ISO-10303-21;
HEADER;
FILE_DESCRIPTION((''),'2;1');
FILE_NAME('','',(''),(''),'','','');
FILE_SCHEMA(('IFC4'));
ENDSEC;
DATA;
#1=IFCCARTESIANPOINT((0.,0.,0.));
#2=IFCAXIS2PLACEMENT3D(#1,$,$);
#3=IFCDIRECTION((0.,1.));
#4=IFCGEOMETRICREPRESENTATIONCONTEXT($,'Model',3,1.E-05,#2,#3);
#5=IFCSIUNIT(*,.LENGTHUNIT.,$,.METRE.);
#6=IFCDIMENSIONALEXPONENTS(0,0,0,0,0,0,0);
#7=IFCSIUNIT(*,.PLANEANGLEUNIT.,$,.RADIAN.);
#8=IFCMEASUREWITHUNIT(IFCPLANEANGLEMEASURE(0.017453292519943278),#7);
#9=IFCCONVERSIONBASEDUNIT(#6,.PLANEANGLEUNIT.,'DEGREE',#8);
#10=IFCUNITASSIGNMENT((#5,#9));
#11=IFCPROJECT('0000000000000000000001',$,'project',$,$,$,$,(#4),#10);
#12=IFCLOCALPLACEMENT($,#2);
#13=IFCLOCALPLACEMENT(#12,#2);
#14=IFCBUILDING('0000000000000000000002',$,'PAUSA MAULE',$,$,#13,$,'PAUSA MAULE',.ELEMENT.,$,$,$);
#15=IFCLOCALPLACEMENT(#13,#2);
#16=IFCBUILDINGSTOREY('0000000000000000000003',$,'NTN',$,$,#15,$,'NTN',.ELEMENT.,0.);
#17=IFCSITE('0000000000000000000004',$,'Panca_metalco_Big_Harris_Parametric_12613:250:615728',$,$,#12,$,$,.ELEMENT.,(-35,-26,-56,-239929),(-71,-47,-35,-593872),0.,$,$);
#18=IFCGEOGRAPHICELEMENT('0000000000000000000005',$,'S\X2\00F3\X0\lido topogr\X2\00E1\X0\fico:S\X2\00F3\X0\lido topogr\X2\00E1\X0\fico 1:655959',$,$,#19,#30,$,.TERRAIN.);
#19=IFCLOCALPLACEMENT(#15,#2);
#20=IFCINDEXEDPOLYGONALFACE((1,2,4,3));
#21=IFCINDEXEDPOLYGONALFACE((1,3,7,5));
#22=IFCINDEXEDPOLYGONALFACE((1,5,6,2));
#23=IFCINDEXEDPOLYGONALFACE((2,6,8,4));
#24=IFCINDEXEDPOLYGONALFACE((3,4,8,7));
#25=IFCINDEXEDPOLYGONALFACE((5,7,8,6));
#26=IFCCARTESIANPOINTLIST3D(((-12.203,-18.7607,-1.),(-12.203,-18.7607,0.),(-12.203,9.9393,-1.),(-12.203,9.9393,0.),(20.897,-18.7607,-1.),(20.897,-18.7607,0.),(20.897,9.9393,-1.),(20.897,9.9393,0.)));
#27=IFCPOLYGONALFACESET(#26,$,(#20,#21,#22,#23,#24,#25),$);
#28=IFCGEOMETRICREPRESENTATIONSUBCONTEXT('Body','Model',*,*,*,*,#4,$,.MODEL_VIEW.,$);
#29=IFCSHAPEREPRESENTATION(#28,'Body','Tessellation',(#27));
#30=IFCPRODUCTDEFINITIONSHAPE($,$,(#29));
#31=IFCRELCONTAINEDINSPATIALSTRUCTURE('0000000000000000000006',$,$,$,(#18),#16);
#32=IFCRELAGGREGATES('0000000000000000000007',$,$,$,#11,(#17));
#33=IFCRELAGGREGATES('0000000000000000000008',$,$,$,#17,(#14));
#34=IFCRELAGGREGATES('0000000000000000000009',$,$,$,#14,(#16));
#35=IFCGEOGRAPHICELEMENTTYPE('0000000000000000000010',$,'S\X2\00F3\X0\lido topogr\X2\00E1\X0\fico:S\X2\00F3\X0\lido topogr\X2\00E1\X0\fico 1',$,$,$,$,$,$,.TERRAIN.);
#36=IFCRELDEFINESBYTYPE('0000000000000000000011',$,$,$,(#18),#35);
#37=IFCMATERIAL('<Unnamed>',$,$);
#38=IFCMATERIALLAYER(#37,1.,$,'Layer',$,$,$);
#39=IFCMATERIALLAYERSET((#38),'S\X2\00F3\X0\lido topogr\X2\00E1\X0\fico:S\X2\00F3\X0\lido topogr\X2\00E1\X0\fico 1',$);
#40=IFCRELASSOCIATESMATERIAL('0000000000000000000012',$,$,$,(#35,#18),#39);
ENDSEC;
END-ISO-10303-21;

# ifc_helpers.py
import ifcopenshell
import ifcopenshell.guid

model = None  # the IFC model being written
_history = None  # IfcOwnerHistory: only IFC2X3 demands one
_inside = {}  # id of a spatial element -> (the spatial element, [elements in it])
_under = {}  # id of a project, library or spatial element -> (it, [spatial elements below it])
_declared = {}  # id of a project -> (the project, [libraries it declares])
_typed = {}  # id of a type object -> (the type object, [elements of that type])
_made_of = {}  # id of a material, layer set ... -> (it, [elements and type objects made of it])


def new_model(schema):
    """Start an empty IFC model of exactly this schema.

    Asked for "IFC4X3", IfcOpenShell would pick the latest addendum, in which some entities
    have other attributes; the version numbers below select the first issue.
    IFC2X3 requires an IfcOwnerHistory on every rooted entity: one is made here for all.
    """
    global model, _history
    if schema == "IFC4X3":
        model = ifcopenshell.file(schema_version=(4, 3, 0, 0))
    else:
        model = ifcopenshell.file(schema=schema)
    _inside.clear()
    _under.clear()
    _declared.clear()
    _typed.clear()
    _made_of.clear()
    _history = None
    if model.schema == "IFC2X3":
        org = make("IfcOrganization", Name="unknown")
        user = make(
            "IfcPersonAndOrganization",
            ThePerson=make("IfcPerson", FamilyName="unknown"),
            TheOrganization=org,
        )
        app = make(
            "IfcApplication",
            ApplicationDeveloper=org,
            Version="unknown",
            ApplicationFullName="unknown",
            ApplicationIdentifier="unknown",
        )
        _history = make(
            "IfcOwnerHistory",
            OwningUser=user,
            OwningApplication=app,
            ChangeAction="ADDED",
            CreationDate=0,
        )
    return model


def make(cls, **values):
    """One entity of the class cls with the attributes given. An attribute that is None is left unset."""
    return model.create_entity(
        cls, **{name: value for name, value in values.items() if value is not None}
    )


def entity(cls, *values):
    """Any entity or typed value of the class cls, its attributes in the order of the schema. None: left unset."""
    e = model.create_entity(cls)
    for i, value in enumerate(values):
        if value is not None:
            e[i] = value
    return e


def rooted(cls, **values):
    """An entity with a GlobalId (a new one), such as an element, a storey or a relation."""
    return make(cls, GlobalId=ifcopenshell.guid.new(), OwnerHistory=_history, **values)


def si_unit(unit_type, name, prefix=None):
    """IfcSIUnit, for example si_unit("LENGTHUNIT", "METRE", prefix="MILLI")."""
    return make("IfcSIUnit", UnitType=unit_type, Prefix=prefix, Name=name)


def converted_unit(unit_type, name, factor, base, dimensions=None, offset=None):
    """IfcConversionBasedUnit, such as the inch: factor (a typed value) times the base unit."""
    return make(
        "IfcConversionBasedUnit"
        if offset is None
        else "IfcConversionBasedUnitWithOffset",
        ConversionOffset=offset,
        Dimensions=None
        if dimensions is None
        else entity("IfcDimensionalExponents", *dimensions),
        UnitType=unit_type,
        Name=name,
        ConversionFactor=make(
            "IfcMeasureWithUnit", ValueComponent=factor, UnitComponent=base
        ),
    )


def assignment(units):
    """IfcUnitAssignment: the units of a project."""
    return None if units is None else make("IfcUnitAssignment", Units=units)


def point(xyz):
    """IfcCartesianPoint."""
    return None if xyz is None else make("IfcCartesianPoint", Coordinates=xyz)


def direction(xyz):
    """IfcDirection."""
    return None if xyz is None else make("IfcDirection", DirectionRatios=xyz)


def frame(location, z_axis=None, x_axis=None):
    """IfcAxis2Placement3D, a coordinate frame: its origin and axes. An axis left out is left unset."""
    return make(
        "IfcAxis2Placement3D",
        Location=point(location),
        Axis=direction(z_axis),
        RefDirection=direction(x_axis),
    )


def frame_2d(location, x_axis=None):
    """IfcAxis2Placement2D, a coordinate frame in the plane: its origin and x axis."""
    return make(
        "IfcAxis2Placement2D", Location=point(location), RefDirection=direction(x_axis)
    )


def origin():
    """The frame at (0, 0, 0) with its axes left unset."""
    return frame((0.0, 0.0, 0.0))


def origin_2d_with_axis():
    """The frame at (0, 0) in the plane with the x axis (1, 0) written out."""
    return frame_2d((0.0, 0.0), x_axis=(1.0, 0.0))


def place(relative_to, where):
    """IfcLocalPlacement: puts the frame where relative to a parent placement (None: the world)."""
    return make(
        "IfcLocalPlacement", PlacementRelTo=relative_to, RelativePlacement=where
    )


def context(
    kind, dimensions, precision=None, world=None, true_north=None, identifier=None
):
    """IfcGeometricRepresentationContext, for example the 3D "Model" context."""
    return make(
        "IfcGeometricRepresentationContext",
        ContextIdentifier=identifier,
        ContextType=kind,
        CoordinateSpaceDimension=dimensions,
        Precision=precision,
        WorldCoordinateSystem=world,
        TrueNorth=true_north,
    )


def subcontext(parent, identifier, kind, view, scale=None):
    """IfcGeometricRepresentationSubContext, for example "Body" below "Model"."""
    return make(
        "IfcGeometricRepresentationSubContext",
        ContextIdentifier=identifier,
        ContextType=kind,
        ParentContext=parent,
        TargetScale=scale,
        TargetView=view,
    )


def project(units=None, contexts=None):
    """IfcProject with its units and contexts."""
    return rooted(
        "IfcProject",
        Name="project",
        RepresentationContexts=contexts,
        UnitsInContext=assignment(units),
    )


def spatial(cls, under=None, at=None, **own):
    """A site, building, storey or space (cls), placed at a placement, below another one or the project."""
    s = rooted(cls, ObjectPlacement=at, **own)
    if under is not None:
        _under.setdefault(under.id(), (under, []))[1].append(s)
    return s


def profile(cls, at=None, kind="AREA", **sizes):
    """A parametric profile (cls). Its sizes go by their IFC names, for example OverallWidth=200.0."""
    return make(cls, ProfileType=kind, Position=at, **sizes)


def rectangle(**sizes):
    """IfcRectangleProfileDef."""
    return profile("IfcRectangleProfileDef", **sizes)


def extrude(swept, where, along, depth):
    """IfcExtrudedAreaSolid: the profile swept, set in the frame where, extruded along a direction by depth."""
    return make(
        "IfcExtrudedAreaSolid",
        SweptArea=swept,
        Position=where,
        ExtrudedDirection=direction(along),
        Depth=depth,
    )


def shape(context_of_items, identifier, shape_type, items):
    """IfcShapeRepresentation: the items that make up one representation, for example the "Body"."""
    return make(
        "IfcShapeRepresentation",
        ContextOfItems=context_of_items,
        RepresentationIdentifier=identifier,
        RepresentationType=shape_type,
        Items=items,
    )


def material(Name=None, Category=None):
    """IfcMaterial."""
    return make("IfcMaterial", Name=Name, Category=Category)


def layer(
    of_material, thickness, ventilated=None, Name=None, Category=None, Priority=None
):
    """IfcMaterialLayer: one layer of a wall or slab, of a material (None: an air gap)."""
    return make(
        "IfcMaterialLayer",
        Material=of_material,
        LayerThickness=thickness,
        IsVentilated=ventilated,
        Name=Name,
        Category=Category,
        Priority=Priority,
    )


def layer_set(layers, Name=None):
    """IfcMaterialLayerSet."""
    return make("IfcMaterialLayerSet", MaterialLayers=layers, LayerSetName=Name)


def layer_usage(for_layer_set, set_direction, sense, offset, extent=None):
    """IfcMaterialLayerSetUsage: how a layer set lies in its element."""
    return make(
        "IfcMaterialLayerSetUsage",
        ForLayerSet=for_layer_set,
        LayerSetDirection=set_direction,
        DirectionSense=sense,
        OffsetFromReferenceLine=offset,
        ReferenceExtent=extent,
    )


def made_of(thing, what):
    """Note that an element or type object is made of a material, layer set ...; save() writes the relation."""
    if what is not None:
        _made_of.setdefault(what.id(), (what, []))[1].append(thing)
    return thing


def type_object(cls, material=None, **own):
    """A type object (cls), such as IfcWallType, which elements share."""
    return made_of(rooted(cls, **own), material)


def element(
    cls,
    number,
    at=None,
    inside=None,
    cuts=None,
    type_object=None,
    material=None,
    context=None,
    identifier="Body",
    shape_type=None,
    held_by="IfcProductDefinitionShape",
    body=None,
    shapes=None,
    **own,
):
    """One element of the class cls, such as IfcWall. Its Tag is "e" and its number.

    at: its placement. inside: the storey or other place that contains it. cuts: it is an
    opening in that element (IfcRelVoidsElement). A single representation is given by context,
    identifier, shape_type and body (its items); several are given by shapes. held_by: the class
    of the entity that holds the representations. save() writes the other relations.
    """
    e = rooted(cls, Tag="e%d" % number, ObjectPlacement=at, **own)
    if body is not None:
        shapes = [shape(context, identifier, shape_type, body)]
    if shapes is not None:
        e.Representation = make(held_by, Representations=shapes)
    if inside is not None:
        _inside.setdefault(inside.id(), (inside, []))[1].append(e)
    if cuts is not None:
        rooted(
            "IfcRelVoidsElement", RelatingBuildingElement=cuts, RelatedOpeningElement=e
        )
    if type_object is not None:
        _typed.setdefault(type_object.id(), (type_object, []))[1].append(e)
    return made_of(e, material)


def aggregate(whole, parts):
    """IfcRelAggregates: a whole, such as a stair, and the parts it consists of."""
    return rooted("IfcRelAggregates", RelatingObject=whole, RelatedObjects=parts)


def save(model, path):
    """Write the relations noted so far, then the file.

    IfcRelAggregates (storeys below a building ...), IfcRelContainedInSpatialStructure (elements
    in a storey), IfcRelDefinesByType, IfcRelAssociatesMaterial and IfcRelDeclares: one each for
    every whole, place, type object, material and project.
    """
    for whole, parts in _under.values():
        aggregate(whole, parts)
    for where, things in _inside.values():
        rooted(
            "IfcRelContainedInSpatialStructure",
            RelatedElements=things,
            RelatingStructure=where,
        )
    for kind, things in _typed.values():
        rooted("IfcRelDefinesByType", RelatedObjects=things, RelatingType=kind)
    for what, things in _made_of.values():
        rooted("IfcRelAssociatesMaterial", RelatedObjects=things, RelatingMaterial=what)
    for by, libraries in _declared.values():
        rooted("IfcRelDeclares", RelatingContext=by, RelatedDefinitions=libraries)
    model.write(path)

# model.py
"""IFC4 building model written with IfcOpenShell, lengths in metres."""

from ifc_helpers import new_model, entity, si_unit, converted_unit, direction, frame, origin, origin_2d_with_axis, place, context, subcontext, project, spatial, rectangle, extrude, material, layer, layer_set, layer_usage, type_object, element, save


model = new_model("IFC4")

# Units and contexts
model_context = context("Model", 3, precision=1e-05, world=origin(), true_north=direction((0.0, 1.0)))
body_context = subcontext(model_context, "Body", "Model", "MODEL_VIEW")
ifc_project = project(units=[si_unit("LENGTHUNIT", "METRE"), converted_unit("PLANEANGLEUNIT", "DEGREE", entity("IfcPlaneAngleMeasure", 0.017453292519943278), si_unit("PLANEANGLEUNIT", "RADIAN"), dimensions=[0, 0, 0, 0, 0, 0, 0])], contexts=[model_context])

# Site, building, storey
site_placement = place(None, origin())
site = spatial("IfcSite", under=ifc_project, at=site_placement, Name="Panca_metalco_Big_Harris_Parametric_12613:250:615728", CompositionType="ELEMENT", RefLatitude=(-35, -26, -56, -239929), RefLongitude=(-71, -47, -35, -593872), RefElevation=0.0)
building_placement = place(site_placement, origin())
building = spatial("IfcBuilding", under=site, at=building_placement, Name="PAUSA MAULE", LongName="PAUSA MAULE", CompositionType="ELEMENT")
storey_placement = place(building_placement, origin())
storey = spatial("IfcBuildingStorey", under=building, at=storey_placement, Name="NTN", LongName="NTN", CompositionType="ELEMENT", Elevation=0.0)

# Geographic element
ifc_material = material(Name="<Unnamed>")
ifc_layer = layer(ifc_material, 1.0, Name="Layer")
ifc_layer_set = layer_set([ifc_layer], Name="Sólido topográfico:Sólido topográfico 1")
ifc_layer_usage = layer_usage(ifc_layer_set, "AXIS3", "NEGATIVE", 0.0)
geographic_element_type = type_object("IfcGeographicElementType", Name="Sólido topográfico:Sólido topográfico 1", PredefinedType="TERRAIN", material=ifc_layer_set)
geographic_element_placement = place(storey_placement, origin())
element("IfcGeographicElement", 1, at=geographic_element_placement, inside=storey, type_object=geographic_element_type, material=ifc_layer_usage, Name="Sólido topográfico:Sólido topográfico 1:655959", PredefinedType="TERRAIN", context=body_context, shape_type="SweptSolid", body=[
    extrude(rectangle(XDim=28.7, YDim=33.1, at=origin_2d_with_axis()), frame((4.347, -4.4107, -1.0), z_axis=(0.0, 0.0, 1.0), x_axis=(0.0, -1.0, 0.0)), (0.0, 0.0, 1.0), 1.0),
])

save(model, "model.ifc")
